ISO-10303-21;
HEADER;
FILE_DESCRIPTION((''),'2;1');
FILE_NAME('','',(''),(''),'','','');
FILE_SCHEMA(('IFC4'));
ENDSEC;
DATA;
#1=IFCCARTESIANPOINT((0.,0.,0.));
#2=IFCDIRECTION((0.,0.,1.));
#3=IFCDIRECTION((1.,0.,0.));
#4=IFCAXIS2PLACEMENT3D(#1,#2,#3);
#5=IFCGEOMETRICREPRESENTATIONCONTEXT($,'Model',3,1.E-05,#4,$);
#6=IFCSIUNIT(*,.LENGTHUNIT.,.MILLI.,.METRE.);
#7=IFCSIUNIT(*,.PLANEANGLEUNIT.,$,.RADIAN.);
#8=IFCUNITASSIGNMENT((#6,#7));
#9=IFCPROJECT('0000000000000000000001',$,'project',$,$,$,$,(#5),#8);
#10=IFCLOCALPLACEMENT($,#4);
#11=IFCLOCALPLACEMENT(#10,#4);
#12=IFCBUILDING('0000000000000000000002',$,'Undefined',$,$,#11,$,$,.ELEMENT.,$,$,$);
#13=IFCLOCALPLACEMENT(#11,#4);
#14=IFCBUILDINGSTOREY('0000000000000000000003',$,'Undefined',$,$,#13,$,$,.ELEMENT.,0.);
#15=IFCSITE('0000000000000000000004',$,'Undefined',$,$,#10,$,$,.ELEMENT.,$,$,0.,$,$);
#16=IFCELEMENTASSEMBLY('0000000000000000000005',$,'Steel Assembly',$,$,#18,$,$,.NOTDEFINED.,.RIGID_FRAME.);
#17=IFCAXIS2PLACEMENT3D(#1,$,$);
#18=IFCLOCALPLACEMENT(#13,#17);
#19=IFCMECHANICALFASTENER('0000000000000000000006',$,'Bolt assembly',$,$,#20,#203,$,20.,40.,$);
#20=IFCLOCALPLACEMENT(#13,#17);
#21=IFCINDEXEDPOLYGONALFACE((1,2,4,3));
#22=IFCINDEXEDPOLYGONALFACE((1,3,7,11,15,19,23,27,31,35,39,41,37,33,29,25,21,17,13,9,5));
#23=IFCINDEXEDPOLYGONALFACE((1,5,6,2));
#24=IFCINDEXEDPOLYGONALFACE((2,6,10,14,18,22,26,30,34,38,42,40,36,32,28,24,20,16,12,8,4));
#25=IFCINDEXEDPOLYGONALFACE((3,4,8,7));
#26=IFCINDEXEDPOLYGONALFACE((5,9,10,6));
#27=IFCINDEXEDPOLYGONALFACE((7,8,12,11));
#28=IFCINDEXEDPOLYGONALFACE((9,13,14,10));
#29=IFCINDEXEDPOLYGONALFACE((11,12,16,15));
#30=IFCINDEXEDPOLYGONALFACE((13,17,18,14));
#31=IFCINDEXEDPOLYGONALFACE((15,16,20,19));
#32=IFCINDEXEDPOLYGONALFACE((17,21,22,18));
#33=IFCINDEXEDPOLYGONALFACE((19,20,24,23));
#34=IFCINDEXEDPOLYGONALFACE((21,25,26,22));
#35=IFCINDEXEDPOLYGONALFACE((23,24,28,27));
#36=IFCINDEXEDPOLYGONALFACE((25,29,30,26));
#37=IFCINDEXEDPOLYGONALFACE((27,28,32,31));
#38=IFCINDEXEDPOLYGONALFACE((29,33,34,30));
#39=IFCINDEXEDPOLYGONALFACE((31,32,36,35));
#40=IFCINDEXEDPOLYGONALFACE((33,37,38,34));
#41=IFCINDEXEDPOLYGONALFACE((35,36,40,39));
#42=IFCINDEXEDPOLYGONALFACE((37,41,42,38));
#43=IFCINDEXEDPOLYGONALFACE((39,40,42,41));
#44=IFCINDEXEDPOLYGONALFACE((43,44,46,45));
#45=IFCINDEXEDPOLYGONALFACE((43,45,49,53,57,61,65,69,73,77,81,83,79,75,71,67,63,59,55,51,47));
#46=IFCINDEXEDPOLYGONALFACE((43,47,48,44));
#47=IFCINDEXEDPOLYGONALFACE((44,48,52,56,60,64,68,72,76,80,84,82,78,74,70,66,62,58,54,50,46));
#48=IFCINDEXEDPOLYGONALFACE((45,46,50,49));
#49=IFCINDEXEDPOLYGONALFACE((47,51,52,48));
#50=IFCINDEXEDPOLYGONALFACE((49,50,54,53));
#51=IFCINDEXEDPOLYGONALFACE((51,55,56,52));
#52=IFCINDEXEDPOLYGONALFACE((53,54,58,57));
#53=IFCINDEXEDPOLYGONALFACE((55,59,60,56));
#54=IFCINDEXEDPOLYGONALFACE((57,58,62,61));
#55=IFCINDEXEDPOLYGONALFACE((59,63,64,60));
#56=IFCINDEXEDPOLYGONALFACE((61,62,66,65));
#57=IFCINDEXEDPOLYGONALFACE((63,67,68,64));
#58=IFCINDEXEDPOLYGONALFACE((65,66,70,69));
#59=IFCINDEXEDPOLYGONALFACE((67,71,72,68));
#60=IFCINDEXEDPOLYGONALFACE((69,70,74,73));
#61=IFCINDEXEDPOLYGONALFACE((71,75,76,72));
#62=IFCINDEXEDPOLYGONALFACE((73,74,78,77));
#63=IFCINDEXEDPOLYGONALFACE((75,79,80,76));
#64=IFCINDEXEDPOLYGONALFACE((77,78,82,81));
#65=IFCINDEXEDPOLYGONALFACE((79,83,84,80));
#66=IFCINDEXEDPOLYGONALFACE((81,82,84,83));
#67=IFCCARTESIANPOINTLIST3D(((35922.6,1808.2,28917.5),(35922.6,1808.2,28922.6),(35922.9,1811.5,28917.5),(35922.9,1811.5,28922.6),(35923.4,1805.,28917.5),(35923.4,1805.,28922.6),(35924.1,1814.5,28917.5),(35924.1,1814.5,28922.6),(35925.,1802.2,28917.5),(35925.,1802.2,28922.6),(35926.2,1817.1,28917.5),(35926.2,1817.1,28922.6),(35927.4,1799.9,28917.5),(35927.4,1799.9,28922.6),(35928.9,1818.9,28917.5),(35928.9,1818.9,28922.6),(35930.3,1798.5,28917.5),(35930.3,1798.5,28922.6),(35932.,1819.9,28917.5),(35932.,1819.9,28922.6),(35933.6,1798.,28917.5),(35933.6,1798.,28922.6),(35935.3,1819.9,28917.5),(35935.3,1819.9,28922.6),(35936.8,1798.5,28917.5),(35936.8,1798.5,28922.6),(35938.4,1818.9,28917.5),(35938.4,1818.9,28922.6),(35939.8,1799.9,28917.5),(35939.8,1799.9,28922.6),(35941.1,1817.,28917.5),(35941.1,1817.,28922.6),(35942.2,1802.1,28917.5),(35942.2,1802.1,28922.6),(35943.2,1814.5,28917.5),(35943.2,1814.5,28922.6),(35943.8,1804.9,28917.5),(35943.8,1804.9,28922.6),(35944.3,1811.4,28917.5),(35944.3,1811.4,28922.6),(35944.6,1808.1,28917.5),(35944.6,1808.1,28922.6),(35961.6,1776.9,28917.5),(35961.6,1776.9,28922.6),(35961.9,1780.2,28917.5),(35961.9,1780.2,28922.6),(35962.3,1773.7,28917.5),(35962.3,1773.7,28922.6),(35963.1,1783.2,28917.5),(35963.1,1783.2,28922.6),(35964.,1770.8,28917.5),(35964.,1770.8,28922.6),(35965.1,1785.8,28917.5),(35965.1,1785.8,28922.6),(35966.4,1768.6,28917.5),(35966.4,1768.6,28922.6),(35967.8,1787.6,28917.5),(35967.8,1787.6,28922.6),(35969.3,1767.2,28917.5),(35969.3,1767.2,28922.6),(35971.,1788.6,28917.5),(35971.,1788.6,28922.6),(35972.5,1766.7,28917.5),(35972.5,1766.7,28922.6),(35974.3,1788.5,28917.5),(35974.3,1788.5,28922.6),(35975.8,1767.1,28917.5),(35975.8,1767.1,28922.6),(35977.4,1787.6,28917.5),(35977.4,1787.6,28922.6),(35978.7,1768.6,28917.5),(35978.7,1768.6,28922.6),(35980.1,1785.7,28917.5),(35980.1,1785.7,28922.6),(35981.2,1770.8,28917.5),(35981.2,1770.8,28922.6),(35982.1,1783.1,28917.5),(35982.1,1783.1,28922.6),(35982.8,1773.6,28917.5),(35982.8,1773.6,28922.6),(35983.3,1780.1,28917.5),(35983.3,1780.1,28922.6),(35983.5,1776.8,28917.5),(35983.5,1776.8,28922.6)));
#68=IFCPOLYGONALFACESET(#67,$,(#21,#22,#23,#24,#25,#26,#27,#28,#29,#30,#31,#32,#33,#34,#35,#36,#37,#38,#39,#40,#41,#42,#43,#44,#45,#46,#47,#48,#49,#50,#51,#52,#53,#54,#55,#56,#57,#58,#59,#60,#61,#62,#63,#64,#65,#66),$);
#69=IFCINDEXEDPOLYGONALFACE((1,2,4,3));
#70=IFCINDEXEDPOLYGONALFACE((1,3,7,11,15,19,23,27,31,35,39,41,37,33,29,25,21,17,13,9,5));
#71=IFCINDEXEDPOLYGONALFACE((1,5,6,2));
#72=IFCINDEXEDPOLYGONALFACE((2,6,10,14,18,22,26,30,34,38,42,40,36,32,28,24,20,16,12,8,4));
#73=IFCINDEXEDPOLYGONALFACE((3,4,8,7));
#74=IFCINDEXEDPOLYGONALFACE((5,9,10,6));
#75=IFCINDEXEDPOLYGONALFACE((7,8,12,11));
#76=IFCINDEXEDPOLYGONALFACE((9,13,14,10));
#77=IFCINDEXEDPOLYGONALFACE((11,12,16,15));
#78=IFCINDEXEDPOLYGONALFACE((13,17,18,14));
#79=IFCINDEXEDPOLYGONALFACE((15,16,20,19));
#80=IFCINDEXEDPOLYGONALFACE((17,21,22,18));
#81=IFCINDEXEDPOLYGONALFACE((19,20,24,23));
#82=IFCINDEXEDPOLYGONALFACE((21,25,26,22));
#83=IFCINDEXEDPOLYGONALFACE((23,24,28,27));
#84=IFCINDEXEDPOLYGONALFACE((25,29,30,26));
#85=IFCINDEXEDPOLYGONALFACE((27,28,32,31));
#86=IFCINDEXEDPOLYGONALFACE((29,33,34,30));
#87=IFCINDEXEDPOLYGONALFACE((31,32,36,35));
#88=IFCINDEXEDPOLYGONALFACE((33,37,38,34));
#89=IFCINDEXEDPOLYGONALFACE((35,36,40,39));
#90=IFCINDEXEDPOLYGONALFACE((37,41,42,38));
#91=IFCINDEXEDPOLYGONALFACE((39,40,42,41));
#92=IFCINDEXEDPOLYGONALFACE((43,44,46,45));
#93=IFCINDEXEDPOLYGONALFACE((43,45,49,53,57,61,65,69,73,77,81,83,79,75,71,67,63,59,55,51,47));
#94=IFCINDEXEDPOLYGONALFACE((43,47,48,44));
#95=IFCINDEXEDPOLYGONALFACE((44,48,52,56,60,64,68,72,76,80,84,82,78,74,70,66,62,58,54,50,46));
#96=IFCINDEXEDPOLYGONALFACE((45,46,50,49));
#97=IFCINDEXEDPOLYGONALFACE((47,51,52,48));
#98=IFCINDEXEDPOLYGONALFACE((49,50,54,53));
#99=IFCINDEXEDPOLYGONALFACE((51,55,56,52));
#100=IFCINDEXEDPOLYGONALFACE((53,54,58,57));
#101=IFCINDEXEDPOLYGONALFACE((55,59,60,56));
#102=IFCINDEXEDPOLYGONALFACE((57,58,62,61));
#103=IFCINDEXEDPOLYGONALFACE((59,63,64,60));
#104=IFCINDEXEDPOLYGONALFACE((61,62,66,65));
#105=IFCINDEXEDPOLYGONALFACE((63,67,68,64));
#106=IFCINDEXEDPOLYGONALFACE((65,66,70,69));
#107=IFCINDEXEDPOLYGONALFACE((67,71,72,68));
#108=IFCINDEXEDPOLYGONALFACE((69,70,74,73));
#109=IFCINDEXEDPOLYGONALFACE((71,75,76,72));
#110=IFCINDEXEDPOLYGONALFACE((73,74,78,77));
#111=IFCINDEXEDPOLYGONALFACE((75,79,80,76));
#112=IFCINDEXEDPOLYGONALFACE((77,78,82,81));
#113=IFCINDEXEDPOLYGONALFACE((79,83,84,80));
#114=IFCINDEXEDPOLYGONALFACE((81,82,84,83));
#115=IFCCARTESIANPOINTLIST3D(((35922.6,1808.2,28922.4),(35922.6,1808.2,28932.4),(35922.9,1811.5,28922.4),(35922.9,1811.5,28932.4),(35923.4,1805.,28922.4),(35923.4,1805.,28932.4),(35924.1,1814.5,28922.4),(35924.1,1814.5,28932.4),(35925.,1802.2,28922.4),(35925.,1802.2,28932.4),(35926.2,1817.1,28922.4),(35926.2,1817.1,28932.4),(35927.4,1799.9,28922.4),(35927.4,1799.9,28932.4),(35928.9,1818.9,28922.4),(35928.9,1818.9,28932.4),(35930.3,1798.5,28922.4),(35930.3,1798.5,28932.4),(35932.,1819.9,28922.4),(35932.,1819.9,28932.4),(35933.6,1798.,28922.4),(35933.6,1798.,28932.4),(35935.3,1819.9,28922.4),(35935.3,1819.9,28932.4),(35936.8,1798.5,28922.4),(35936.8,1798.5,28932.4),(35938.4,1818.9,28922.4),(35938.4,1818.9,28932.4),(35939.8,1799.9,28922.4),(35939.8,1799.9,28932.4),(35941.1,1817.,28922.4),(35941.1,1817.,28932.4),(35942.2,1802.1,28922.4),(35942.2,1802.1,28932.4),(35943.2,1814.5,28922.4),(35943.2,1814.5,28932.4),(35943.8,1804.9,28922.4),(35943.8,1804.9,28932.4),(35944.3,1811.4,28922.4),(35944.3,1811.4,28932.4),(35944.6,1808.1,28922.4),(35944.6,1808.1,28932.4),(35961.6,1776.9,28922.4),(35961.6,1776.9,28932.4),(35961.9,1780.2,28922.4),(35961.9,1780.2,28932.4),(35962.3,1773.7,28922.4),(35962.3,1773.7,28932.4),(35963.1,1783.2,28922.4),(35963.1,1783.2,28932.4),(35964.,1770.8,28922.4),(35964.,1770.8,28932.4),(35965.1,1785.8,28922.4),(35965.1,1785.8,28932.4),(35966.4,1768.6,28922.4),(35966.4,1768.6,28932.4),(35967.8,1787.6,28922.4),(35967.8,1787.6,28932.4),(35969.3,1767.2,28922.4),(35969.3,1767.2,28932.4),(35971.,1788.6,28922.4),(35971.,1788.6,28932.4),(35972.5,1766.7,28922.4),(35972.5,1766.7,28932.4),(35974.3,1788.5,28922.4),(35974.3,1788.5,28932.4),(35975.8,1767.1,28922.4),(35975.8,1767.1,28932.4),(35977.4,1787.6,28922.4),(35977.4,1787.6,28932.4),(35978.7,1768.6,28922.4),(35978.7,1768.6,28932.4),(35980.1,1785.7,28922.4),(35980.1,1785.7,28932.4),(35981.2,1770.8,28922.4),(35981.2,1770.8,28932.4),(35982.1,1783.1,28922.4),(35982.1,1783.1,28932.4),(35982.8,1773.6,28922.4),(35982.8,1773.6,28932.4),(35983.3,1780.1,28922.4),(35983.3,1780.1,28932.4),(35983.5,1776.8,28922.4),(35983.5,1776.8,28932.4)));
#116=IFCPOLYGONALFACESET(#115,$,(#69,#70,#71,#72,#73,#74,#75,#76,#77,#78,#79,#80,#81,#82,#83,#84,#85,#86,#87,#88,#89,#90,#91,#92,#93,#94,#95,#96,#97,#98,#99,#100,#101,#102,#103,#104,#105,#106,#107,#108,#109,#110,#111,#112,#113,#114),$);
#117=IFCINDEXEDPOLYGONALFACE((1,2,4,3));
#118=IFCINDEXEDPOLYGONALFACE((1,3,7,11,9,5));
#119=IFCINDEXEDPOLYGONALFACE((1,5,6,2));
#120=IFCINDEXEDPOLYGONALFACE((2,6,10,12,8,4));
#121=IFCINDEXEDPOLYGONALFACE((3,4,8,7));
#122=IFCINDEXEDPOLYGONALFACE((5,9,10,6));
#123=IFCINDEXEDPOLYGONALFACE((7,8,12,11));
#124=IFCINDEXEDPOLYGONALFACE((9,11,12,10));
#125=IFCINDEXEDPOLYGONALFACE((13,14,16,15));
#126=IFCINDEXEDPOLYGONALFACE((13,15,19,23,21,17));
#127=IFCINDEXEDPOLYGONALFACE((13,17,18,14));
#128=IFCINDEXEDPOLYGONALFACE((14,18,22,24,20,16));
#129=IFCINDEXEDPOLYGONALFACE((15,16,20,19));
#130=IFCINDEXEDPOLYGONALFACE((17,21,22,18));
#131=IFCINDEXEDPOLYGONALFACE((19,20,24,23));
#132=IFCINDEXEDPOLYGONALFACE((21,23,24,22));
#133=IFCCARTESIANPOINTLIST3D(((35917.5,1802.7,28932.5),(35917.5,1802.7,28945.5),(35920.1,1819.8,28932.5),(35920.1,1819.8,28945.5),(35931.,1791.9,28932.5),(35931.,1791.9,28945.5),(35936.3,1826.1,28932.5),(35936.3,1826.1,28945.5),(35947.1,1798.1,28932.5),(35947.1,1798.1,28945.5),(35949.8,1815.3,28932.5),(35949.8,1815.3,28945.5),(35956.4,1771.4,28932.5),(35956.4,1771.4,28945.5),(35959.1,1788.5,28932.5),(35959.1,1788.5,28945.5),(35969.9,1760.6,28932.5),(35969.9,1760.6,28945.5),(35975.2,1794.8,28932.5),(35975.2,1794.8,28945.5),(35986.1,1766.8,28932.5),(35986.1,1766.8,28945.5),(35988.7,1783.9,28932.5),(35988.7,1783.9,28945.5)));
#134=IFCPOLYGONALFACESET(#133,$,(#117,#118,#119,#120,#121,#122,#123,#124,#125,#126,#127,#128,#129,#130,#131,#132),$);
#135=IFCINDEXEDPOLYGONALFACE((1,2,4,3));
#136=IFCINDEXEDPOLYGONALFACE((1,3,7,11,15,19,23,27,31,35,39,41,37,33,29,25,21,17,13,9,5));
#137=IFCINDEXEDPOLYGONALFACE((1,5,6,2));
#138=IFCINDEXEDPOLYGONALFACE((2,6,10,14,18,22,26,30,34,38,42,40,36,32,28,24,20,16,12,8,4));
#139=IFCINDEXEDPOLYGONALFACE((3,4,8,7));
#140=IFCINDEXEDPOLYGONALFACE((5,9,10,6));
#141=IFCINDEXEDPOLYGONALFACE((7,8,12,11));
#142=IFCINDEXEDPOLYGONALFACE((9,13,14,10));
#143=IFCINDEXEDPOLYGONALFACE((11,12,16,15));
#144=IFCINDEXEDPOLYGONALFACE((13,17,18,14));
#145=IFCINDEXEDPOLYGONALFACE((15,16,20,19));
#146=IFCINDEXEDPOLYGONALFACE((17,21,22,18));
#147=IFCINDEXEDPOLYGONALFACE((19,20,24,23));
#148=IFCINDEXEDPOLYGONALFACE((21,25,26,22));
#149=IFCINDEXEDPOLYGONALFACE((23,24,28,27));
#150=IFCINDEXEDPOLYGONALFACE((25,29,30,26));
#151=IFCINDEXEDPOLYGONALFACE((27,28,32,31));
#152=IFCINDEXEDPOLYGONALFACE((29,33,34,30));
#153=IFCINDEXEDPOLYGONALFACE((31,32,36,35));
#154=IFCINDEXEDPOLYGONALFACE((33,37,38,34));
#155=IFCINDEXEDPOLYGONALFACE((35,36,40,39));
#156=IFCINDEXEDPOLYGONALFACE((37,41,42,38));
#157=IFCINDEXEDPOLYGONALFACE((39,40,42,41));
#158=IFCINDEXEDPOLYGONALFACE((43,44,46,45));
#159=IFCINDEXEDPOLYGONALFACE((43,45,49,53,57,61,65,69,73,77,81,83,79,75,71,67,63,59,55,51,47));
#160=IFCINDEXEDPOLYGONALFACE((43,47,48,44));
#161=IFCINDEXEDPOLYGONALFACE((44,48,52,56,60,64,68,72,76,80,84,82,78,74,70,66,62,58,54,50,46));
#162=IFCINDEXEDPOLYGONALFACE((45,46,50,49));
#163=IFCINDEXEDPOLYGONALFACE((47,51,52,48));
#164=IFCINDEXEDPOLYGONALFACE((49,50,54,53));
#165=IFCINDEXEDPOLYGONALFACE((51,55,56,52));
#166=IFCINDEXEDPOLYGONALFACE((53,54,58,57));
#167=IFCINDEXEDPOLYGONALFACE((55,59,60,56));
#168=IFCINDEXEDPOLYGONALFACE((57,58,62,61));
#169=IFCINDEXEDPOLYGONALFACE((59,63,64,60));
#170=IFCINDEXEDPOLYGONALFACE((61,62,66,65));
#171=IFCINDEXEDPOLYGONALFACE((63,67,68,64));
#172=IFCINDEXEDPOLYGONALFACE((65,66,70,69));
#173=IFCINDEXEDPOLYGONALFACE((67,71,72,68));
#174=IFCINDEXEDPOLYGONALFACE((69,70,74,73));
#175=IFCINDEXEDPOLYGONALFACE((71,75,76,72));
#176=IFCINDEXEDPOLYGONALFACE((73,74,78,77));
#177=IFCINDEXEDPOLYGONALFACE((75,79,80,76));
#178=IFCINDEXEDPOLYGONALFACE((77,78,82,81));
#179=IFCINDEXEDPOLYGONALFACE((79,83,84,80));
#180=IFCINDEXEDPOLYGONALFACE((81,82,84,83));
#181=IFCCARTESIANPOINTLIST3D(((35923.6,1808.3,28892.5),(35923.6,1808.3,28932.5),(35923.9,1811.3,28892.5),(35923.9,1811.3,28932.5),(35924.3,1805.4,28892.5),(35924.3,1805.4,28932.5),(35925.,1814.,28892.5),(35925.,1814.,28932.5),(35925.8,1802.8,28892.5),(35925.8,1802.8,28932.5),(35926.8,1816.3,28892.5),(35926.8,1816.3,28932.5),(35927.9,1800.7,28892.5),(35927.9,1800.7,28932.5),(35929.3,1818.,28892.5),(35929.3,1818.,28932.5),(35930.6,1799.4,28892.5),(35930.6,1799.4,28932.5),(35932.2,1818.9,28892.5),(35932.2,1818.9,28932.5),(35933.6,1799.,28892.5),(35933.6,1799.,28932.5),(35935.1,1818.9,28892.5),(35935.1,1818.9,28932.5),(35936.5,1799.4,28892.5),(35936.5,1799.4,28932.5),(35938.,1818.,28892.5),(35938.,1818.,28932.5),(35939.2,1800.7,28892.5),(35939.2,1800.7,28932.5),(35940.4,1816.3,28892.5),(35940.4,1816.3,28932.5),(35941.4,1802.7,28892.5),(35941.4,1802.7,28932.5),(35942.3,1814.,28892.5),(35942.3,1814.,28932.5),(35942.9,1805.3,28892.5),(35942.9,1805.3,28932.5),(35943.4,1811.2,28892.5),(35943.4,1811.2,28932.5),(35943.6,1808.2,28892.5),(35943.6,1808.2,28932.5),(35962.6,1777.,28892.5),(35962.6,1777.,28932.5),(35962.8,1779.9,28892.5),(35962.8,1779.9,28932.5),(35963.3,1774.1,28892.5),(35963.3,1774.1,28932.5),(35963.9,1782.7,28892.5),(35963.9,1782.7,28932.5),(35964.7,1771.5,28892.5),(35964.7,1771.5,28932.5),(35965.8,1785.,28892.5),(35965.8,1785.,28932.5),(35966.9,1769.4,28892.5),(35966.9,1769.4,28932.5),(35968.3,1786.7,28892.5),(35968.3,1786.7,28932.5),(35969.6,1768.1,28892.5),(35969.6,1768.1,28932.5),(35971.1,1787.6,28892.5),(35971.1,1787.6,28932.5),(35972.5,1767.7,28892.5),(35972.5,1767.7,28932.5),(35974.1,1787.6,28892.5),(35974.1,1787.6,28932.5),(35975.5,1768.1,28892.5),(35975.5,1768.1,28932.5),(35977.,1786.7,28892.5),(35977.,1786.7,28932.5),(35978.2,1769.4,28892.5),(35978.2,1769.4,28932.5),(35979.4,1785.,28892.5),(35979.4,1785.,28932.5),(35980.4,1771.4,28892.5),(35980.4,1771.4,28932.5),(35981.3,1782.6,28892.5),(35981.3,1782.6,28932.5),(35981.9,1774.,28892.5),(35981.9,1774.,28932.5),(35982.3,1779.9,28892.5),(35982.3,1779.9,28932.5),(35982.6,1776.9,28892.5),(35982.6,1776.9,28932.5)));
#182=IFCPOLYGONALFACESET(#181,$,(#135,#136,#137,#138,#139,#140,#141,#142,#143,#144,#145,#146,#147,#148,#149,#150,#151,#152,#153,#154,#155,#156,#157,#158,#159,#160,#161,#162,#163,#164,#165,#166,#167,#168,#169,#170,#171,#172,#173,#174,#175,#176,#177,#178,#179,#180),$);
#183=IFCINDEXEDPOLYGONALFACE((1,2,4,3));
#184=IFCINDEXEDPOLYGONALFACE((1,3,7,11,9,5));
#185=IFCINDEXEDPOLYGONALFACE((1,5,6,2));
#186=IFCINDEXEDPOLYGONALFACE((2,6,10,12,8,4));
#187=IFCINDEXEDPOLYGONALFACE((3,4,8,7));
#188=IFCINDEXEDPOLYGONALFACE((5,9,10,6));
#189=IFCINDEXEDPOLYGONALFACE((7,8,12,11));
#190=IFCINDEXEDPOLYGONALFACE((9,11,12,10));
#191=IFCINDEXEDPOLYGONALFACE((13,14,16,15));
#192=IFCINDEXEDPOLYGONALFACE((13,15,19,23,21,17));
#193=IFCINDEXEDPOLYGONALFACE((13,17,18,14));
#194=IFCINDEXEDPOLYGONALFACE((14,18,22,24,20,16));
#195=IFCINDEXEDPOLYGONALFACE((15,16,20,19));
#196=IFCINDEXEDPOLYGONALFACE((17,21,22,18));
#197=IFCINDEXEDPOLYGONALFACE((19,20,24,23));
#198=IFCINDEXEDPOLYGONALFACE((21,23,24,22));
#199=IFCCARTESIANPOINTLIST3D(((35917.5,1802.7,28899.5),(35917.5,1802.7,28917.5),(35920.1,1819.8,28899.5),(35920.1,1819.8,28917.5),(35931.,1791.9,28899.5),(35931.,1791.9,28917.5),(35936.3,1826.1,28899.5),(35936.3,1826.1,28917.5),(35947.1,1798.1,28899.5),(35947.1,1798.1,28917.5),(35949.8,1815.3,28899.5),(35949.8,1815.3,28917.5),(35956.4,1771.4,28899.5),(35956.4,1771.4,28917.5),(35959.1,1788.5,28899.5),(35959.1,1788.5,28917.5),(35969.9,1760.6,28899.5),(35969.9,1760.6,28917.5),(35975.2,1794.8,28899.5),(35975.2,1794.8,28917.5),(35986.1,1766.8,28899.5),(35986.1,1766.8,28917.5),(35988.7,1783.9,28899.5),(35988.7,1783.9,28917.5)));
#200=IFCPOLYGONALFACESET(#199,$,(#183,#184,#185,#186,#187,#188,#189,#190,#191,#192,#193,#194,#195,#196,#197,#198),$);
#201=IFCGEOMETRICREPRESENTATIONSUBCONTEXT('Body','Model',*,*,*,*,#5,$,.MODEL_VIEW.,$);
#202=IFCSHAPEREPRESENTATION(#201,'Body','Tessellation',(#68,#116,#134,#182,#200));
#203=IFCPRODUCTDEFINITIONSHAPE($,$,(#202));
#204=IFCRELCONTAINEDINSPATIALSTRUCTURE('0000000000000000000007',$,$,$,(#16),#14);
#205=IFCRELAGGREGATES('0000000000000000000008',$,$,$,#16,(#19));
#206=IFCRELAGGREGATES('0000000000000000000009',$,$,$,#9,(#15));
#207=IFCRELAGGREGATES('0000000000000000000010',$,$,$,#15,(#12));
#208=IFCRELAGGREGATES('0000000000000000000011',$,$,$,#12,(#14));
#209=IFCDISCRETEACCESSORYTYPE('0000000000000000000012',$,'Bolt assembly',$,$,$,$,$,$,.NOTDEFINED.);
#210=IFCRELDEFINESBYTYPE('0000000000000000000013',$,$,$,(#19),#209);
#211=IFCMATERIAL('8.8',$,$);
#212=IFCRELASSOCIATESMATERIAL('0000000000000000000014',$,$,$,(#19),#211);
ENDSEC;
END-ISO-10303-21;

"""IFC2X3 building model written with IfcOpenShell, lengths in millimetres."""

from ifc_helpers import new_model, si_unit, frame, origin_with_axes, origin_2d_with_axis, place, context, subcontext, project, spatial, polyline, circle, outline, extrude, source, transform, mapped, material, type_object, element, aggregate, save


model = new_model("IFC2X3")

# Units and contexts
model_context = context("Model", 3, precision=1e-05, world=origin_with_axes())
body_context = subcontext(model_context, "Body", "Model", "MODEL_VIEW")
ifc_project = project(units=[si_unit("LENGTHUNIT", "METRE", prefix="MILLI"), si_unit("PLANEANGLEUNIT", "RADIAN")], contexts=[model_context])

# Site, building, storey
site_placement = place(None, origin_with_axes())
site = spatial("IfcSite", under=ifc_project, at=site_placement, Name="Undefined", CompositionType="ELEMENT", RefElevation=0.0)
building_placement = place(site_placement, origin_with_axes())
building = spatial("IfcBuilding", under=site, at=building_placement, Name="Undefined", CompositionType="ELEMENT")
storey_placement = place(building_placement, origin_with_axes())
storey = spatial("IfcBuildingStorey", under=building, at=storey_placement, Name="Undefined", CompositionType="ELEMENT", Elevation=0.0)

# Element assembly
assembly_1_placement = place(storey_placement, origin_with_axes())
assembly_1 = element("IfcElementAssembly", 1, at=assembly_1_placement, inside=storey, Name="Steel Assembly", AssemblyPlace="NOTDEFINED", PredefinedType="RIGID_FRAME")

# Shared definitions
discrete_accessory_type_1 = type_object("IfcDiscreteAccessoryType", Name="Bolt assembly")

# Mechanical fastener
ifc_material_1 = material(Name="8.8")
shared_shape_1 = source(origin_with_axes(), body_context, "Body", "SweptSolid", [
    extrude(circle(Radius=11.0, at=origin_2d_with_axis()), frame((0.0, -0.1, 0.0), z_axis=(0.0, 1.0, 0.0), x_axis=(1.0, 0.0, 0.0)), (0.0, 0.0, 1.0), 5.1),
    extrude(circle(Radius=11.0, at=origin_2d_with_axis()), frame((0.0, -9.9, 0.0), z_axis=(0.0, 1.0, 0.0), x_axis=(1.0, 0.0, 0.0)), (0.0, 0.0, 1.0), 10.0),
    extrude(outline(polyline([(17.3, 0.0), (8.7, 15.0), (-8.7, 15.0), (-17.3, 0.0), (-8.7, -15.0), (8.7, -15.0), (17.3, 0.0)])), frame((0.0, -23.0, 0.0), z_axis=(0.0, 1.0, 0.0), x_axis=(1.0, 0.0, 0.0)), (0.0, 0.0, 1.0), 13.0),
    extrude(circle(Radius=10.0, at=origin_2d_with_axis()), frame((0.0, -10.0, 0.0), z_axis=(0.0, 1.0, 0.0), x_axis=(1.0, 0.0, 0.0)), (0.0, 0.0, 1.0), 40.0),
    extrude(outline(polyline([(17.3, 0.0), (8.7, 15.0), (-8.7, 15.0), (-17.3, 0.0), (-8.7, -15.0), (8.7, -15.0), (17.3, 0.0)])), frame((0.0, 5.0, 0.0), z_axis=(0.0, 1.0, 0.0), x_axis=(1.0, 0.0, 0.0)), (0.0, 0.0, 1.0), 18.0),
])
mechanical_fastener_1_placement = place(assembly_1_placement, frame((35933.6, 1809.0, 28922.5), z_axis=(0.626358, 0.779536, 0.0), x_axis=(0.779536, -0.626358, 0.0)))
mechanical_fastener_1 = element("IfcMechanicalFastener", 2, at=mechanical_fastener_1_placement, type_object=discrete_accessory_type_1, material=ifc_material_1, Name="Bolt assembly", NominalDiameter=20.0, NominalLength=40.0, context=body_context, shape_type="MappedRepresentation", body=[
    mapped(shared_shape_1, transform((0.0, 0.0, 0.0))),
    mapped(shared_shape_1, transform((50.0, 0.0, 0.0))),
])
aggregate(assembly_1, [mechanical_fastener_1])

save(model, "model.ifc")
